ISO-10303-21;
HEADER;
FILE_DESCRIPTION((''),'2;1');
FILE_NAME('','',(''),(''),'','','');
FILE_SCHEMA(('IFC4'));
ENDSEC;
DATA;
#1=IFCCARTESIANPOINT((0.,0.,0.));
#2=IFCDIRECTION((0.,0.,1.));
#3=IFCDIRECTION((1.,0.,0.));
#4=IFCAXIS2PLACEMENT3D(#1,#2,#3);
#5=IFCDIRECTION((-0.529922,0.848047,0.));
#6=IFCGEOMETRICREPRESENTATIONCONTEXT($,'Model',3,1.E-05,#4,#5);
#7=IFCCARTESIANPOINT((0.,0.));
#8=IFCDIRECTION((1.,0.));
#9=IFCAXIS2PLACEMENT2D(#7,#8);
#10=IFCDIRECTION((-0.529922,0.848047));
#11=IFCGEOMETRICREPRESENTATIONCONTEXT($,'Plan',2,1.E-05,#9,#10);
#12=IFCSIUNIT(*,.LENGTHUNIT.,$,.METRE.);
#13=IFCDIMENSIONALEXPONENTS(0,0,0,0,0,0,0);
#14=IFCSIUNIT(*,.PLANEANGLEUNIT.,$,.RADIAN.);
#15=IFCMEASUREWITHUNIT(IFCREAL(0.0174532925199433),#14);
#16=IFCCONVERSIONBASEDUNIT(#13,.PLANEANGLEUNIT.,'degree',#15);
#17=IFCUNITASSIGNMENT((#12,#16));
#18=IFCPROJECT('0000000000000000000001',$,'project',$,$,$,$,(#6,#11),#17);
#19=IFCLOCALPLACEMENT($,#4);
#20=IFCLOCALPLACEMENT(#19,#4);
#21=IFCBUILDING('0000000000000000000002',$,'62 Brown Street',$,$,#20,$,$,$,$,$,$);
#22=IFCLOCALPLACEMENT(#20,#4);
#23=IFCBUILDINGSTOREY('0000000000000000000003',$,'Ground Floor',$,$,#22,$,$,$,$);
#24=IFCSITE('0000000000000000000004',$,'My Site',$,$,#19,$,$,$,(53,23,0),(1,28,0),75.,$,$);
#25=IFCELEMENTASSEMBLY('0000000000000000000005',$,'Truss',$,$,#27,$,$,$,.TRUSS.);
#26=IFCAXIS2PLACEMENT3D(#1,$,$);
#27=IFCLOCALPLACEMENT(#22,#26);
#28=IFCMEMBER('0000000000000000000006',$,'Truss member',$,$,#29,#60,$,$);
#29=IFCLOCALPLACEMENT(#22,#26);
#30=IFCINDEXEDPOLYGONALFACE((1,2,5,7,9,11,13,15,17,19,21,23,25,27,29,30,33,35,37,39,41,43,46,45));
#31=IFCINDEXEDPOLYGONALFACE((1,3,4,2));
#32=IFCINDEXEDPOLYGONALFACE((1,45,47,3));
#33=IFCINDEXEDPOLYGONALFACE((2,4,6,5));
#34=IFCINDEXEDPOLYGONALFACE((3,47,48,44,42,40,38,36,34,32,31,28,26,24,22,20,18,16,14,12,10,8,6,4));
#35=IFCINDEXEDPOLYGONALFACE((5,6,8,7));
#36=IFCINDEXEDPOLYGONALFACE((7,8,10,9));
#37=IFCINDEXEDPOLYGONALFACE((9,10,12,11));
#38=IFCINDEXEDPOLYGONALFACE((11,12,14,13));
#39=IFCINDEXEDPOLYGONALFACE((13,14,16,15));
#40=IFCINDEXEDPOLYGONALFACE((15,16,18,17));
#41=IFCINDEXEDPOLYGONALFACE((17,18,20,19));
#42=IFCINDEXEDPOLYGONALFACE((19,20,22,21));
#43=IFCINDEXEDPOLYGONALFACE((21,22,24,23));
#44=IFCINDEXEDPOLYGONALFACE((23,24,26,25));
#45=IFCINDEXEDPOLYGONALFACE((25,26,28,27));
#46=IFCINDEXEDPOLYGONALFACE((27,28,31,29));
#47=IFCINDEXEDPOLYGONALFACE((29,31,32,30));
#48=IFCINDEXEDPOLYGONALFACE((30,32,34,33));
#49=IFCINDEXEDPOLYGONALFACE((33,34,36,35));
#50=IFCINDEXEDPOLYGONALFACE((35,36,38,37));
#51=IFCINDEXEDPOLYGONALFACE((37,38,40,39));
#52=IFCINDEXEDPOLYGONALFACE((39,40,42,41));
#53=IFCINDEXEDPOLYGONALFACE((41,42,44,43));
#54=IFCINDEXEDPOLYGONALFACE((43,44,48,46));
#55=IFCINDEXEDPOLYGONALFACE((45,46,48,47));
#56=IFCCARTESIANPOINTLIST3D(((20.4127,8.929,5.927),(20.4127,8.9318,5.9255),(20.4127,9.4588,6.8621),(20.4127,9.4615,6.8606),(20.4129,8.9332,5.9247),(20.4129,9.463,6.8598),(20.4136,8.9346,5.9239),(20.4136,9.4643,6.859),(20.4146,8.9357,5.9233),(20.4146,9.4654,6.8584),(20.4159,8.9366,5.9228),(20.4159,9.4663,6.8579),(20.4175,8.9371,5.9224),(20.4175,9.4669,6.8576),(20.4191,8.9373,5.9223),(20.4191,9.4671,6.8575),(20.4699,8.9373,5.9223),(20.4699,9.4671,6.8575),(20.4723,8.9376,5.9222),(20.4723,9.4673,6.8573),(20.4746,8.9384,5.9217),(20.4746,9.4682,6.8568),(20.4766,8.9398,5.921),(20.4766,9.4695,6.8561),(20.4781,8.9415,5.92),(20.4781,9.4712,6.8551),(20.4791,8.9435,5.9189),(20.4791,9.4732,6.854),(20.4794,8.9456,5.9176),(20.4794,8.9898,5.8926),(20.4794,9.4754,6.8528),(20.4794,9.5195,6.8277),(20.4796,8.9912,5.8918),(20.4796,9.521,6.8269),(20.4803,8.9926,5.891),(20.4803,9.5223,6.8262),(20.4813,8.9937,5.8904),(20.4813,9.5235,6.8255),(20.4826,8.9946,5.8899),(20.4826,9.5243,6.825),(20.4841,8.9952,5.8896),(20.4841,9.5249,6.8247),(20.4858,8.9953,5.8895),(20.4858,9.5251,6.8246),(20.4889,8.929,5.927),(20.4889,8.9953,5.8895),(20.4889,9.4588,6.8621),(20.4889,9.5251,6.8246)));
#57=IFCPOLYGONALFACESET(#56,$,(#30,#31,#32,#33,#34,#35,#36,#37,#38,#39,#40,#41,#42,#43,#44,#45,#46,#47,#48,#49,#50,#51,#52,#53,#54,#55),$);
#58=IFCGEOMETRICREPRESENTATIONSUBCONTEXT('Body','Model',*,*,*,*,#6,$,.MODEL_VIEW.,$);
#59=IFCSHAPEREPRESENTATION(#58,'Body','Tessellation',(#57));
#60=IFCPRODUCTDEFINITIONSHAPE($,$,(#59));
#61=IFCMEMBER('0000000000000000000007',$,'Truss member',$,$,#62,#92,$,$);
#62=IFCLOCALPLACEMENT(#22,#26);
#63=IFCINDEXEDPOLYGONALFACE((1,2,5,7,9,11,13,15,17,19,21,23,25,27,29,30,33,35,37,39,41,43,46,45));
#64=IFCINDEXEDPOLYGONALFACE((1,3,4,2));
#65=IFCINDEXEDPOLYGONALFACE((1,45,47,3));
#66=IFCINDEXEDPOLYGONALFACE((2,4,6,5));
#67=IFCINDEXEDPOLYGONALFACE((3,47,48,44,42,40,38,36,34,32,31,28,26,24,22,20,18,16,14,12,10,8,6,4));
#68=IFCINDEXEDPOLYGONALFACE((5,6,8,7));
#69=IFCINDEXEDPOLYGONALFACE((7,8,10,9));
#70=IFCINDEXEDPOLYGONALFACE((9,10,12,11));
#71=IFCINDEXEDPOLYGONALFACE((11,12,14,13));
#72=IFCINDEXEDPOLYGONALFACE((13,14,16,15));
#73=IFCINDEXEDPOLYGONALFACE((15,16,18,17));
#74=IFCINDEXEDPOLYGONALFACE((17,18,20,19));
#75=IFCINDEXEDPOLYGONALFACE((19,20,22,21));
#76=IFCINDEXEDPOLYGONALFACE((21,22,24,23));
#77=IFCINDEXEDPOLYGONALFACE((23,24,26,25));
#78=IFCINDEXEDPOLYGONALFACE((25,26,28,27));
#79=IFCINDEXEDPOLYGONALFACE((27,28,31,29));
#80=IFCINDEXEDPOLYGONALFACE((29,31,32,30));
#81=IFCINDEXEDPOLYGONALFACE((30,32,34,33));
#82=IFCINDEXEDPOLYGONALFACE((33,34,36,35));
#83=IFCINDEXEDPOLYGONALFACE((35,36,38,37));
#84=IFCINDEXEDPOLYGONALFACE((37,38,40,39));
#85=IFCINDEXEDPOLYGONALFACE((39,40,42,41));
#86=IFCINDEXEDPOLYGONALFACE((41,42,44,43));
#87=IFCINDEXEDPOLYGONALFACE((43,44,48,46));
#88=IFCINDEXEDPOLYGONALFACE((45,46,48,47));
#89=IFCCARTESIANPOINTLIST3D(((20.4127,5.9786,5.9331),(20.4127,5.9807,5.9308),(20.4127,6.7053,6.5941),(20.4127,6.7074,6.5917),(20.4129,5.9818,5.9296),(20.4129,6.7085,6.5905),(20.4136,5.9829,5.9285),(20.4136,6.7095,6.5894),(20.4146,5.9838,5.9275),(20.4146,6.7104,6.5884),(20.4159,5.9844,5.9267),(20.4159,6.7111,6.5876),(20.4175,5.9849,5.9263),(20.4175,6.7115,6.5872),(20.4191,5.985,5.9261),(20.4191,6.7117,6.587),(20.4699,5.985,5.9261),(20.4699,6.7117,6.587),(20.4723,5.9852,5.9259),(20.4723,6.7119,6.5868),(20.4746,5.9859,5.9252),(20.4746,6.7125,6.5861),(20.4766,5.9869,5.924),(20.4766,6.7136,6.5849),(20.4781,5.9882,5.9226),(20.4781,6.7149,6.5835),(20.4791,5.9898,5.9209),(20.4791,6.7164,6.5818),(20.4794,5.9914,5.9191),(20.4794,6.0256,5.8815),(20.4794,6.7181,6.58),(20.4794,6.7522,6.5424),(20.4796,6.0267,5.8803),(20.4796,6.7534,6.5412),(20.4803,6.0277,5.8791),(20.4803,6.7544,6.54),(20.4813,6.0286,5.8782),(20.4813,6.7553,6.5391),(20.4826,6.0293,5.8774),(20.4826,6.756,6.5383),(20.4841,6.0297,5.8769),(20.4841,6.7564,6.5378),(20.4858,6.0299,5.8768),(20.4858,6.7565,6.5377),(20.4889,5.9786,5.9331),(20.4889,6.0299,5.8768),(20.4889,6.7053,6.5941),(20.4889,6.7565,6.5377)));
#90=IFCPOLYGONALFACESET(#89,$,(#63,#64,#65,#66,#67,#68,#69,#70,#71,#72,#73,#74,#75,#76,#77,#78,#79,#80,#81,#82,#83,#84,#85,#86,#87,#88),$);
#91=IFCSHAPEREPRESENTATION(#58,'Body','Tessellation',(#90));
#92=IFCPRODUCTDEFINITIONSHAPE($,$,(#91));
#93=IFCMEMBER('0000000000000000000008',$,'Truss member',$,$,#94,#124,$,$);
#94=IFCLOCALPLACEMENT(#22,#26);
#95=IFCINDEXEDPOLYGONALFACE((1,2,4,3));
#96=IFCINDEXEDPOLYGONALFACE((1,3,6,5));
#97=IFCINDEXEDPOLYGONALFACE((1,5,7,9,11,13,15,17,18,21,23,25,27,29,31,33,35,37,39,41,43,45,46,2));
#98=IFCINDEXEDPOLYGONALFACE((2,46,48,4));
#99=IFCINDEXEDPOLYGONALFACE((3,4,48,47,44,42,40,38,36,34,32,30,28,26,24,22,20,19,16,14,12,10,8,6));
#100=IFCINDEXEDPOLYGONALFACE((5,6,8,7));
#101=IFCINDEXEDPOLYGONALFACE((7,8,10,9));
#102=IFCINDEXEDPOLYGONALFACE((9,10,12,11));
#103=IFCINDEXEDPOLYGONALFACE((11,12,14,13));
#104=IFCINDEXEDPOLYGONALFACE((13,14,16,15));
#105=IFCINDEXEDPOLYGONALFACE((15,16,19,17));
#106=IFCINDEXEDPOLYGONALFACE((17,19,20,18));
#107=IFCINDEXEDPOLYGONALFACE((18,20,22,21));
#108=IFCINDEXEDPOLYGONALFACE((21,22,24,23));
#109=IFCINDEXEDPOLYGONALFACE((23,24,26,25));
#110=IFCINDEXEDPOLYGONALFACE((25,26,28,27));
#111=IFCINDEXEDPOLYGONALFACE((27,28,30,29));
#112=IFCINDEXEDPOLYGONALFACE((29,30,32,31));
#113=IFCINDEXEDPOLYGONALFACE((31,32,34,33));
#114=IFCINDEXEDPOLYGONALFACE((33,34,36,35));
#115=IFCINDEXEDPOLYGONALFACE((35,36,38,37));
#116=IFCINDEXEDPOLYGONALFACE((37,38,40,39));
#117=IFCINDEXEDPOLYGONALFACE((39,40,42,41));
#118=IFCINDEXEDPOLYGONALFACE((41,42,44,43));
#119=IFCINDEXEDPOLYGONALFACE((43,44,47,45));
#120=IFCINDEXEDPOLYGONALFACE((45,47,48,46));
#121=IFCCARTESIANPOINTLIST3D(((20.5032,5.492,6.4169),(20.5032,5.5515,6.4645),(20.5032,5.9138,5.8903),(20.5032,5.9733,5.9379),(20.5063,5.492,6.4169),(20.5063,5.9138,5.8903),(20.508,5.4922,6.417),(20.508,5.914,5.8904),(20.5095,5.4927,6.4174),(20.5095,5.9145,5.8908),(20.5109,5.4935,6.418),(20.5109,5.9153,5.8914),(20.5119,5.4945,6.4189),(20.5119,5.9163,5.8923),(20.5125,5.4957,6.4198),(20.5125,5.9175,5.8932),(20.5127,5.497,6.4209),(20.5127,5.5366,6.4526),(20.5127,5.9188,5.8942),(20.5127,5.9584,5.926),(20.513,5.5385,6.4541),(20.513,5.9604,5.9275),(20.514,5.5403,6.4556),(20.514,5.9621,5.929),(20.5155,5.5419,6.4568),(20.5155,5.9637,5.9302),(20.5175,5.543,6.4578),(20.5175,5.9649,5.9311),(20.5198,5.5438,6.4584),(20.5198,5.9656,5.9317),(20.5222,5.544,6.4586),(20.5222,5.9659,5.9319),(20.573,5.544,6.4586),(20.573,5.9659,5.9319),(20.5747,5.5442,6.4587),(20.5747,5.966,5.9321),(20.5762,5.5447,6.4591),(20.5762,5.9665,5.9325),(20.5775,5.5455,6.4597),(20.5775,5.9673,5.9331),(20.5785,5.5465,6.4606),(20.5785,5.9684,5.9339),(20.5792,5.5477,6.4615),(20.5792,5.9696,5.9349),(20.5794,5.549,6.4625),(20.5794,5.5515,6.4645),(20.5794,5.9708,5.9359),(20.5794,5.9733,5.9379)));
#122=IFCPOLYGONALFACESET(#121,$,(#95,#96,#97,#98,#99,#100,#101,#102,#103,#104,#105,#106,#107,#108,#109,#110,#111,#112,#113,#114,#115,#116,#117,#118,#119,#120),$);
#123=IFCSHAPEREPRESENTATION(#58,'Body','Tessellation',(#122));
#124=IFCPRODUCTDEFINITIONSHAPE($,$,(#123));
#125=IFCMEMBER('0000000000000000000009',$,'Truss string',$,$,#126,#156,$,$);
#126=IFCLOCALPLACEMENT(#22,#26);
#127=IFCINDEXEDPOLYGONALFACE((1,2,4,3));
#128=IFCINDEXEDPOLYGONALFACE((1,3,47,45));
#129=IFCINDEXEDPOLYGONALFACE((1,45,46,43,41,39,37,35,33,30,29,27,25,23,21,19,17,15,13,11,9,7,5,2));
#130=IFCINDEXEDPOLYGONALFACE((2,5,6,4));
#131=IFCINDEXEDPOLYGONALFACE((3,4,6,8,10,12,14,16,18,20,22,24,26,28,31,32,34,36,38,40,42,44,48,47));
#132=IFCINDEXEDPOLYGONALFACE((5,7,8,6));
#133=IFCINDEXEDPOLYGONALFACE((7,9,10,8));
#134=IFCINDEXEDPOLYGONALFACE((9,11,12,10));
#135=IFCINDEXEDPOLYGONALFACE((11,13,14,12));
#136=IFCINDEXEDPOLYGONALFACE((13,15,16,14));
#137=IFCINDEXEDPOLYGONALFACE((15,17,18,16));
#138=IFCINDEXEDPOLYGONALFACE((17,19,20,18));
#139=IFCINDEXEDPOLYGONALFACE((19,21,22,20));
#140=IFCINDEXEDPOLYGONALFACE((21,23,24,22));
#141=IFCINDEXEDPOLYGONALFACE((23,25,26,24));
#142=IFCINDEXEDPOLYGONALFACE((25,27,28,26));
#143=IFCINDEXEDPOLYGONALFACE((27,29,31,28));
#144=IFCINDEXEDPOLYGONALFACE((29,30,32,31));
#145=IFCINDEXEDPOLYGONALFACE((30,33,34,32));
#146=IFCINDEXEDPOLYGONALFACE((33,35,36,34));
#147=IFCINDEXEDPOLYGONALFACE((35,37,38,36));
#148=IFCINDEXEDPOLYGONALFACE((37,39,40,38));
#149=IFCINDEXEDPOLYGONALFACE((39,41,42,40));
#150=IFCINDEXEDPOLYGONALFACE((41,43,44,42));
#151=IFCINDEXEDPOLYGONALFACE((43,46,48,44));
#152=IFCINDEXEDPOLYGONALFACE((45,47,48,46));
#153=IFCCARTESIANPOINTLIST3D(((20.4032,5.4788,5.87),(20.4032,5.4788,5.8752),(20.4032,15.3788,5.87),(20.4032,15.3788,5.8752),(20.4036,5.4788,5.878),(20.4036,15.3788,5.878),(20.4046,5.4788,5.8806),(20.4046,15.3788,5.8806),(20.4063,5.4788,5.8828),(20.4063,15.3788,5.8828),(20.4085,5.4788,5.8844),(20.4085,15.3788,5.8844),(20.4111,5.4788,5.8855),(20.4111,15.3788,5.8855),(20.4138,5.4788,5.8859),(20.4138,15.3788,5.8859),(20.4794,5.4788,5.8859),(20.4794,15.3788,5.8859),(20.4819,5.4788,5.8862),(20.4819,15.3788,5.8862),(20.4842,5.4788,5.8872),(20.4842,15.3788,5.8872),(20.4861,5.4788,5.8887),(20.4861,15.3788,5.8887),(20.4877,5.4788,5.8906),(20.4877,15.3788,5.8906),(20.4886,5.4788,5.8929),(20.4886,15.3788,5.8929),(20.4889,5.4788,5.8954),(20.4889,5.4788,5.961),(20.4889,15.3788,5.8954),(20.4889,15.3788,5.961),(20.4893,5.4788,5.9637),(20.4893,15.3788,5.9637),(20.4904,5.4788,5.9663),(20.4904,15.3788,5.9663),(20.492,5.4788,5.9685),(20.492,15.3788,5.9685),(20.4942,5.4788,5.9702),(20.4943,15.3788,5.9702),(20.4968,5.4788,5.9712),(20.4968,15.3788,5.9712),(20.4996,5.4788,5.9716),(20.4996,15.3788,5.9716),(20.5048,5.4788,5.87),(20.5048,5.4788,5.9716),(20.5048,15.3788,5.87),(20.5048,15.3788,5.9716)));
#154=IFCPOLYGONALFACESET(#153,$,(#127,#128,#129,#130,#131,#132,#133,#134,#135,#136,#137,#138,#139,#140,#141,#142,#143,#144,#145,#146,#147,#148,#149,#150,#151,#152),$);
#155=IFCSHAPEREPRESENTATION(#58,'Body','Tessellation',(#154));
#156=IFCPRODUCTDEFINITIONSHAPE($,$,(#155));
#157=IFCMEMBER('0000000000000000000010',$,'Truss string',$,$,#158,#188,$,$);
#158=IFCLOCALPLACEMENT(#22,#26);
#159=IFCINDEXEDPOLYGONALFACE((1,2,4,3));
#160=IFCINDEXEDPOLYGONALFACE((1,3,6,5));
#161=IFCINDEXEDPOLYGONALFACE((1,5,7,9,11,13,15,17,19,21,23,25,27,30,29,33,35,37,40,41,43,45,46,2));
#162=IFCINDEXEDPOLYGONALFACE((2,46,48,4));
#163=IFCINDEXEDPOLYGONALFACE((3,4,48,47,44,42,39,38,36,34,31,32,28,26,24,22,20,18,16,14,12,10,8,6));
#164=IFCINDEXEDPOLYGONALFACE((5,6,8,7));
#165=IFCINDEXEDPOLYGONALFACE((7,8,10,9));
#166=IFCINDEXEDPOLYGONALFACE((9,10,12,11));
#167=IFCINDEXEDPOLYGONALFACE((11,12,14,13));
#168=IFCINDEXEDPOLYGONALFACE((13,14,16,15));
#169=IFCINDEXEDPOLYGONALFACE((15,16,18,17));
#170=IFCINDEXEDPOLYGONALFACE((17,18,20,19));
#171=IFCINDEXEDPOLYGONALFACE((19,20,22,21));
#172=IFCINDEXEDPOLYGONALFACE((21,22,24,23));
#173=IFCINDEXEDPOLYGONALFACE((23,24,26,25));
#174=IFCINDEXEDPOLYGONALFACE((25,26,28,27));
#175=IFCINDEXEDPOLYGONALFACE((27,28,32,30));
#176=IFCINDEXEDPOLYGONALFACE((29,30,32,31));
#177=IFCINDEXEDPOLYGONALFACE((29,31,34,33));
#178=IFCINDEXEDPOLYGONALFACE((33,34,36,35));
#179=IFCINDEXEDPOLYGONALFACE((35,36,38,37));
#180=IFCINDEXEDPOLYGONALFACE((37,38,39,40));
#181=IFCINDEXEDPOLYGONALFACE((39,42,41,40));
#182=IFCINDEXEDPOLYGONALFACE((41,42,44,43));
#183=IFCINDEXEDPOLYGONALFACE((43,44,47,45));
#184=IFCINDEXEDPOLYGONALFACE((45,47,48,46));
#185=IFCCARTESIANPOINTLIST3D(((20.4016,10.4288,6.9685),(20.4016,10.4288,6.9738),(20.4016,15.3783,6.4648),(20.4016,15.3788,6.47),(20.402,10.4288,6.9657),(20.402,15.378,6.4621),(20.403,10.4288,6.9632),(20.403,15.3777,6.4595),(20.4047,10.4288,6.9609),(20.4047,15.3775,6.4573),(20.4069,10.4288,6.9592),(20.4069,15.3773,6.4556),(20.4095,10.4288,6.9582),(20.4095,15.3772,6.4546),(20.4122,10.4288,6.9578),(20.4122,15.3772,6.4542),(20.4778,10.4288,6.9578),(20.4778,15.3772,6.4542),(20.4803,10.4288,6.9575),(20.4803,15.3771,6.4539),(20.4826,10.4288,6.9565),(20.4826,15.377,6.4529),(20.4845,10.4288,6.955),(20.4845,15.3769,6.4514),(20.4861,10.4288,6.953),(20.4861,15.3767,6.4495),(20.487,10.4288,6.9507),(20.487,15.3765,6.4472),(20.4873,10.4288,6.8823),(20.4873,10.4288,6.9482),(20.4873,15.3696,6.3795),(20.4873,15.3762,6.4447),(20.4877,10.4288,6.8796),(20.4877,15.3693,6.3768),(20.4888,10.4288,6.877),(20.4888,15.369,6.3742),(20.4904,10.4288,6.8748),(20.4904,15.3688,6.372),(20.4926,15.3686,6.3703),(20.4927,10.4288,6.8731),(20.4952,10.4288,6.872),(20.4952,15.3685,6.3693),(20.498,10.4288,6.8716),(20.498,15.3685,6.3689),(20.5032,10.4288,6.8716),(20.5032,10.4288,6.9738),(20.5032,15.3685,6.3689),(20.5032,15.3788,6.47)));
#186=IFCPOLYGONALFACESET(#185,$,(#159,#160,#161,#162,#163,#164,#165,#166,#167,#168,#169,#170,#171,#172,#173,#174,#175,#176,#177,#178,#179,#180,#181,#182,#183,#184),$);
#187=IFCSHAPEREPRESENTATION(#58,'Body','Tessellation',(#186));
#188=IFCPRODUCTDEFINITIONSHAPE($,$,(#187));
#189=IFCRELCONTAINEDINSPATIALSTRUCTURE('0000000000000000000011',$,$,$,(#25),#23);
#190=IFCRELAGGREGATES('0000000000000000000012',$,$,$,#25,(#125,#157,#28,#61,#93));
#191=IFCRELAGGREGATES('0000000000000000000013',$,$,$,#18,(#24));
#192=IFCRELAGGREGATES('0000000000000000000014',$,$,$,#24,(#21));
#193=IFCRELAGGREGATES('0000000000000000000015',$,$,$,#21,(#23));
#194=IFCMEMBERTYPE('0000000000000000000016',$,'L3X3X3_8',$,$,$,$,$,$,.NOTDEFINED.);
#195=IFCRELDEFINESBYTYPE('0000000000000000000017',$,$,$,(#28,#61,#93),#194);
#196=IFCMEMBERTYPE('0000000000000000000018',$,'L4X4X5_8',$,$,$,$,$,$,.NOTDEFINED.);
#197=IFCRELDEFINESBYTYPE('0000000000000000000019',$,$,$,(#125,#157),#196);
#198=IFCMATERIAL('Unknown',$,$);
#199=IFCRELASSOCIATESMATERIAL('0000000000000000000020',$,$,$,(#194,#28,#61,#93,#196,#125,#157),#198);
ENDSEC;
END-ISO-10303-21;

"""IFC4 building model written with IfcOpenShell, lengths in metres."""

from ifc_helpers import new_model, entity, si_unit, converted_unit, direction, frame, origin_with_axes, origin_2d_with_axis, place, context, subcontext, project, spatial, l_section, extrude, clip, halfspace, material, material_profile, profile_set, profile_usage, type_object, element, aggregate, save


model = new_model("IFC4")

# Units and contexts
model_context = context("Model", 3, precision=1e-05, world=origin_with_axes(), true_north=direction((-0.529922, 0.848047, 0.0)))
plan_context = context("Plan", 2, precision=1e-05, world=origin_2d_with_axis(), true_north=direction((-0.529922, 0.848047)))
body_context_1 = subcontext(model_context, "Body", "Model", "MODEL_VIEW")
ifc_project = project(units=[si_unit("LENGTHUNIT", "METRE"), converted_unit("PLANEANGLEUNIT", "degree", entity("IfcReal", 0.0174532925199433), si_unit("PLANEANGLEUNIT", "RADIAN"), dimensions=[0, 0, 0, 0, 0, 0, 0])], contexts=[model_context, plan_context])

# Site, building, storey
site_placement = place(None, origin_with_axes())
site = spatial("IfcSite", under=ifc_project, at=site_placement, Name="My Site", RefLatitude=(53, 23, 0), RefLongitude=(1, 28, 0), RefElevation=75.0)
building_placement = place(site_placement, origin_with_axes())
building = spatial("IfcBuilding", under=site, at=building_placement, Name="62 Brown Street")
storey_placement = place(building_placement, origin_with_axes())
storey = spatial("IfcBuildingStorey", under=building, at=storey_placement, Name="Ground Floor")

# Element assembly, members
assembly_placement = place(storey_placement, frame((20.5032, 10.4288, 6.9738), z_axis=(0.0, 0.0, 1.0), x_axis=(1.0, 0.0, 0.0)))
assembly = element("IfcElementAssembly", 1, at=assembly_placement, inside=storey, Name="Truss", PredefinedType="TRUSS")
ifc_material_1 = material(Name="Unknown")
ifc_material_profile_1 = material_profile(ifc_material_1, l_section(Depth=0.0762, Width=0.0762, Thickness=0.0095, FilletRadius=0.0095, EdgeRadius=0.0064))
ifc_profile_set_1 = profile_set([ifc_material_profile_1])
member_type_1 = type_object("IfcMemberType", Name="L3X3X3_8", PredefinedType="NOTDEFINED", material=ifc_profile_set_1)
ifc_profile_usage_1 = profile_usage(ifc_profile_set_1, cardinal=5)
member_1_placement = place(assembly_placement, frame((-0.0524, -0.9369, -0.1304), z_axis=(0.0, -0.492899, -0.870086), x_axis=(-1.0, 0.0, 0.0)))
member_1 = element("IfcMember", 2, at=member_1_placement, type_object=member_type_1, material=ifc_profile_usage_1, Name="Truss member", context=body_context_1, shape_type="SweptSolid", body=[
    extrude(l_section(Depth=0.0762, Width=0.0762, Thickness=0.0095, FilletRadius=0.0095, EdgeRadius=0.0064), origin_with_axes(), (0.0, 0.0, 1.0), 1.0747),
])
ifc_profile_usage_2 = profile_usage(ifc_profile_set_1, cardinal=5)
member_2_placement = place(assembly_placement, frame((-0.0524, -3.6979, -0.4079), z_axis=(0.000001, -0.739785, -0.672843), x_axis=(-1.0, -0.000001, 0.0)))
member_2 = element("IfcMember", 3, at=member_2_placement, type_object=member_type_1, material=ifc_profile_usage_2, Name="Truss member", context=body_context_1, shape_type="SweptSolid", body=[
    extrude(l_section(Depth=0.0762, Width=0.0762, Thickness=0.0095, FilletRadius=0.0095, EdgeRadius=0.0064), origin_with_axes(), (0.0, 0.0, 1.0), 0.9823),
])
ifc_profile_usage_3 = profile_usage(ifc_profile_set_1, cardinal=5)
member_3_placement = place(assembly_placement, frame((0.0381, -4.907, -0.5331), z_axis=(-0.000001, 0.625169, -0.780489), x_axis=(1.0, 0.000001, 0.0)))
member_3 = element("IfcMember", 4, at=member_3_placement, type_object=member_type_1, material=ifc_profile_usage_3, Name="Truss member", context=body_context_1, shape_type="SweptSolid", body=[
    extrude(l_section(Depth=0.0762, Width=0.0762, Thickness=0.0095, FilletRadius=0.0095, EdgeRadius=0.0064), origin_with_axes(), (0.0, 0.0, 1.0), 0.6747),
])

# Members
ifc_material_profile_2 = material_profile(ifc_material_1, l_section(Depth=0.1016, Width=0.1016, Thickness=0.0159, FilletRadius=0.0095, EdgeRadius=0.0106))
ifc_profile_set_2 = profile_set([ifc_material_profile_2])
ifc_profile_usage_4 = profile_usage(ifc_profile_set_2, cardinal=5)
member_type_2 = type_object("IfcMemberType", Name="L4X4X5_8", PredefinedType="NOTDEFINED", material=ifc_profile_set_2)
member_4_placement = place(assembly_placement, frame((-0.0492, -4.95, -1.053), z_axis=(0.0, 1.0, 0.0), x_axis=(-1.0, 0.0, 0.0)))
member_4 = element("IfcMember", 5, at=member_4_placement, type_object=member_type_2, material=ifc_profile_usage_4, Name="Truss string", context=body_context_1, shape_type="SweptSolid", body=[
    extrude(l_section(Depth=0.1016, Width=0.1016, Thickness=0.0159, FilletRadius=0.0095, EdgeRadius=0.0106), origin_with_axes(), (0.0, 0.0, 1.0), 9.9),
])
ifc_profile_usage_5 = profile_usage(ifc_profile_set_2, cardinal=5)
member_5_placement = place(assembly_placement, frame((-0.0508, 4.9449, -0.5543), z_axis=(0.000001, -0.994861, 0.101247), x_axis=(-1.0, -0.000001, 0.0)))
member_5 = element("IfcMember", 6, at=member_5_placement, type_object=member_type_2, material=ifc_profile_usage_5, Name="Truss string", context=body_context_1, shape_type="Clipping", body=[
    clip(extrude(l_section(Depth=0.1016, Width=0.1016, Thickness=0.0159, FilletRadius=0.0095, EdgeRadius=0.0106), origin_with_axes(), (0.0, 0.0, 1.0), 5.3242), halfspace(frame((16.4524, -0.0508, 4.9756), z_axis=(0.0, 0.101247, 0.994861), x_axis=(1.0, -0.000001, 0.0)), False)),
])
aggregate(assembly, [member_4, member_5, member_1, member_2, member_3])

save(model, "model.ifc")
